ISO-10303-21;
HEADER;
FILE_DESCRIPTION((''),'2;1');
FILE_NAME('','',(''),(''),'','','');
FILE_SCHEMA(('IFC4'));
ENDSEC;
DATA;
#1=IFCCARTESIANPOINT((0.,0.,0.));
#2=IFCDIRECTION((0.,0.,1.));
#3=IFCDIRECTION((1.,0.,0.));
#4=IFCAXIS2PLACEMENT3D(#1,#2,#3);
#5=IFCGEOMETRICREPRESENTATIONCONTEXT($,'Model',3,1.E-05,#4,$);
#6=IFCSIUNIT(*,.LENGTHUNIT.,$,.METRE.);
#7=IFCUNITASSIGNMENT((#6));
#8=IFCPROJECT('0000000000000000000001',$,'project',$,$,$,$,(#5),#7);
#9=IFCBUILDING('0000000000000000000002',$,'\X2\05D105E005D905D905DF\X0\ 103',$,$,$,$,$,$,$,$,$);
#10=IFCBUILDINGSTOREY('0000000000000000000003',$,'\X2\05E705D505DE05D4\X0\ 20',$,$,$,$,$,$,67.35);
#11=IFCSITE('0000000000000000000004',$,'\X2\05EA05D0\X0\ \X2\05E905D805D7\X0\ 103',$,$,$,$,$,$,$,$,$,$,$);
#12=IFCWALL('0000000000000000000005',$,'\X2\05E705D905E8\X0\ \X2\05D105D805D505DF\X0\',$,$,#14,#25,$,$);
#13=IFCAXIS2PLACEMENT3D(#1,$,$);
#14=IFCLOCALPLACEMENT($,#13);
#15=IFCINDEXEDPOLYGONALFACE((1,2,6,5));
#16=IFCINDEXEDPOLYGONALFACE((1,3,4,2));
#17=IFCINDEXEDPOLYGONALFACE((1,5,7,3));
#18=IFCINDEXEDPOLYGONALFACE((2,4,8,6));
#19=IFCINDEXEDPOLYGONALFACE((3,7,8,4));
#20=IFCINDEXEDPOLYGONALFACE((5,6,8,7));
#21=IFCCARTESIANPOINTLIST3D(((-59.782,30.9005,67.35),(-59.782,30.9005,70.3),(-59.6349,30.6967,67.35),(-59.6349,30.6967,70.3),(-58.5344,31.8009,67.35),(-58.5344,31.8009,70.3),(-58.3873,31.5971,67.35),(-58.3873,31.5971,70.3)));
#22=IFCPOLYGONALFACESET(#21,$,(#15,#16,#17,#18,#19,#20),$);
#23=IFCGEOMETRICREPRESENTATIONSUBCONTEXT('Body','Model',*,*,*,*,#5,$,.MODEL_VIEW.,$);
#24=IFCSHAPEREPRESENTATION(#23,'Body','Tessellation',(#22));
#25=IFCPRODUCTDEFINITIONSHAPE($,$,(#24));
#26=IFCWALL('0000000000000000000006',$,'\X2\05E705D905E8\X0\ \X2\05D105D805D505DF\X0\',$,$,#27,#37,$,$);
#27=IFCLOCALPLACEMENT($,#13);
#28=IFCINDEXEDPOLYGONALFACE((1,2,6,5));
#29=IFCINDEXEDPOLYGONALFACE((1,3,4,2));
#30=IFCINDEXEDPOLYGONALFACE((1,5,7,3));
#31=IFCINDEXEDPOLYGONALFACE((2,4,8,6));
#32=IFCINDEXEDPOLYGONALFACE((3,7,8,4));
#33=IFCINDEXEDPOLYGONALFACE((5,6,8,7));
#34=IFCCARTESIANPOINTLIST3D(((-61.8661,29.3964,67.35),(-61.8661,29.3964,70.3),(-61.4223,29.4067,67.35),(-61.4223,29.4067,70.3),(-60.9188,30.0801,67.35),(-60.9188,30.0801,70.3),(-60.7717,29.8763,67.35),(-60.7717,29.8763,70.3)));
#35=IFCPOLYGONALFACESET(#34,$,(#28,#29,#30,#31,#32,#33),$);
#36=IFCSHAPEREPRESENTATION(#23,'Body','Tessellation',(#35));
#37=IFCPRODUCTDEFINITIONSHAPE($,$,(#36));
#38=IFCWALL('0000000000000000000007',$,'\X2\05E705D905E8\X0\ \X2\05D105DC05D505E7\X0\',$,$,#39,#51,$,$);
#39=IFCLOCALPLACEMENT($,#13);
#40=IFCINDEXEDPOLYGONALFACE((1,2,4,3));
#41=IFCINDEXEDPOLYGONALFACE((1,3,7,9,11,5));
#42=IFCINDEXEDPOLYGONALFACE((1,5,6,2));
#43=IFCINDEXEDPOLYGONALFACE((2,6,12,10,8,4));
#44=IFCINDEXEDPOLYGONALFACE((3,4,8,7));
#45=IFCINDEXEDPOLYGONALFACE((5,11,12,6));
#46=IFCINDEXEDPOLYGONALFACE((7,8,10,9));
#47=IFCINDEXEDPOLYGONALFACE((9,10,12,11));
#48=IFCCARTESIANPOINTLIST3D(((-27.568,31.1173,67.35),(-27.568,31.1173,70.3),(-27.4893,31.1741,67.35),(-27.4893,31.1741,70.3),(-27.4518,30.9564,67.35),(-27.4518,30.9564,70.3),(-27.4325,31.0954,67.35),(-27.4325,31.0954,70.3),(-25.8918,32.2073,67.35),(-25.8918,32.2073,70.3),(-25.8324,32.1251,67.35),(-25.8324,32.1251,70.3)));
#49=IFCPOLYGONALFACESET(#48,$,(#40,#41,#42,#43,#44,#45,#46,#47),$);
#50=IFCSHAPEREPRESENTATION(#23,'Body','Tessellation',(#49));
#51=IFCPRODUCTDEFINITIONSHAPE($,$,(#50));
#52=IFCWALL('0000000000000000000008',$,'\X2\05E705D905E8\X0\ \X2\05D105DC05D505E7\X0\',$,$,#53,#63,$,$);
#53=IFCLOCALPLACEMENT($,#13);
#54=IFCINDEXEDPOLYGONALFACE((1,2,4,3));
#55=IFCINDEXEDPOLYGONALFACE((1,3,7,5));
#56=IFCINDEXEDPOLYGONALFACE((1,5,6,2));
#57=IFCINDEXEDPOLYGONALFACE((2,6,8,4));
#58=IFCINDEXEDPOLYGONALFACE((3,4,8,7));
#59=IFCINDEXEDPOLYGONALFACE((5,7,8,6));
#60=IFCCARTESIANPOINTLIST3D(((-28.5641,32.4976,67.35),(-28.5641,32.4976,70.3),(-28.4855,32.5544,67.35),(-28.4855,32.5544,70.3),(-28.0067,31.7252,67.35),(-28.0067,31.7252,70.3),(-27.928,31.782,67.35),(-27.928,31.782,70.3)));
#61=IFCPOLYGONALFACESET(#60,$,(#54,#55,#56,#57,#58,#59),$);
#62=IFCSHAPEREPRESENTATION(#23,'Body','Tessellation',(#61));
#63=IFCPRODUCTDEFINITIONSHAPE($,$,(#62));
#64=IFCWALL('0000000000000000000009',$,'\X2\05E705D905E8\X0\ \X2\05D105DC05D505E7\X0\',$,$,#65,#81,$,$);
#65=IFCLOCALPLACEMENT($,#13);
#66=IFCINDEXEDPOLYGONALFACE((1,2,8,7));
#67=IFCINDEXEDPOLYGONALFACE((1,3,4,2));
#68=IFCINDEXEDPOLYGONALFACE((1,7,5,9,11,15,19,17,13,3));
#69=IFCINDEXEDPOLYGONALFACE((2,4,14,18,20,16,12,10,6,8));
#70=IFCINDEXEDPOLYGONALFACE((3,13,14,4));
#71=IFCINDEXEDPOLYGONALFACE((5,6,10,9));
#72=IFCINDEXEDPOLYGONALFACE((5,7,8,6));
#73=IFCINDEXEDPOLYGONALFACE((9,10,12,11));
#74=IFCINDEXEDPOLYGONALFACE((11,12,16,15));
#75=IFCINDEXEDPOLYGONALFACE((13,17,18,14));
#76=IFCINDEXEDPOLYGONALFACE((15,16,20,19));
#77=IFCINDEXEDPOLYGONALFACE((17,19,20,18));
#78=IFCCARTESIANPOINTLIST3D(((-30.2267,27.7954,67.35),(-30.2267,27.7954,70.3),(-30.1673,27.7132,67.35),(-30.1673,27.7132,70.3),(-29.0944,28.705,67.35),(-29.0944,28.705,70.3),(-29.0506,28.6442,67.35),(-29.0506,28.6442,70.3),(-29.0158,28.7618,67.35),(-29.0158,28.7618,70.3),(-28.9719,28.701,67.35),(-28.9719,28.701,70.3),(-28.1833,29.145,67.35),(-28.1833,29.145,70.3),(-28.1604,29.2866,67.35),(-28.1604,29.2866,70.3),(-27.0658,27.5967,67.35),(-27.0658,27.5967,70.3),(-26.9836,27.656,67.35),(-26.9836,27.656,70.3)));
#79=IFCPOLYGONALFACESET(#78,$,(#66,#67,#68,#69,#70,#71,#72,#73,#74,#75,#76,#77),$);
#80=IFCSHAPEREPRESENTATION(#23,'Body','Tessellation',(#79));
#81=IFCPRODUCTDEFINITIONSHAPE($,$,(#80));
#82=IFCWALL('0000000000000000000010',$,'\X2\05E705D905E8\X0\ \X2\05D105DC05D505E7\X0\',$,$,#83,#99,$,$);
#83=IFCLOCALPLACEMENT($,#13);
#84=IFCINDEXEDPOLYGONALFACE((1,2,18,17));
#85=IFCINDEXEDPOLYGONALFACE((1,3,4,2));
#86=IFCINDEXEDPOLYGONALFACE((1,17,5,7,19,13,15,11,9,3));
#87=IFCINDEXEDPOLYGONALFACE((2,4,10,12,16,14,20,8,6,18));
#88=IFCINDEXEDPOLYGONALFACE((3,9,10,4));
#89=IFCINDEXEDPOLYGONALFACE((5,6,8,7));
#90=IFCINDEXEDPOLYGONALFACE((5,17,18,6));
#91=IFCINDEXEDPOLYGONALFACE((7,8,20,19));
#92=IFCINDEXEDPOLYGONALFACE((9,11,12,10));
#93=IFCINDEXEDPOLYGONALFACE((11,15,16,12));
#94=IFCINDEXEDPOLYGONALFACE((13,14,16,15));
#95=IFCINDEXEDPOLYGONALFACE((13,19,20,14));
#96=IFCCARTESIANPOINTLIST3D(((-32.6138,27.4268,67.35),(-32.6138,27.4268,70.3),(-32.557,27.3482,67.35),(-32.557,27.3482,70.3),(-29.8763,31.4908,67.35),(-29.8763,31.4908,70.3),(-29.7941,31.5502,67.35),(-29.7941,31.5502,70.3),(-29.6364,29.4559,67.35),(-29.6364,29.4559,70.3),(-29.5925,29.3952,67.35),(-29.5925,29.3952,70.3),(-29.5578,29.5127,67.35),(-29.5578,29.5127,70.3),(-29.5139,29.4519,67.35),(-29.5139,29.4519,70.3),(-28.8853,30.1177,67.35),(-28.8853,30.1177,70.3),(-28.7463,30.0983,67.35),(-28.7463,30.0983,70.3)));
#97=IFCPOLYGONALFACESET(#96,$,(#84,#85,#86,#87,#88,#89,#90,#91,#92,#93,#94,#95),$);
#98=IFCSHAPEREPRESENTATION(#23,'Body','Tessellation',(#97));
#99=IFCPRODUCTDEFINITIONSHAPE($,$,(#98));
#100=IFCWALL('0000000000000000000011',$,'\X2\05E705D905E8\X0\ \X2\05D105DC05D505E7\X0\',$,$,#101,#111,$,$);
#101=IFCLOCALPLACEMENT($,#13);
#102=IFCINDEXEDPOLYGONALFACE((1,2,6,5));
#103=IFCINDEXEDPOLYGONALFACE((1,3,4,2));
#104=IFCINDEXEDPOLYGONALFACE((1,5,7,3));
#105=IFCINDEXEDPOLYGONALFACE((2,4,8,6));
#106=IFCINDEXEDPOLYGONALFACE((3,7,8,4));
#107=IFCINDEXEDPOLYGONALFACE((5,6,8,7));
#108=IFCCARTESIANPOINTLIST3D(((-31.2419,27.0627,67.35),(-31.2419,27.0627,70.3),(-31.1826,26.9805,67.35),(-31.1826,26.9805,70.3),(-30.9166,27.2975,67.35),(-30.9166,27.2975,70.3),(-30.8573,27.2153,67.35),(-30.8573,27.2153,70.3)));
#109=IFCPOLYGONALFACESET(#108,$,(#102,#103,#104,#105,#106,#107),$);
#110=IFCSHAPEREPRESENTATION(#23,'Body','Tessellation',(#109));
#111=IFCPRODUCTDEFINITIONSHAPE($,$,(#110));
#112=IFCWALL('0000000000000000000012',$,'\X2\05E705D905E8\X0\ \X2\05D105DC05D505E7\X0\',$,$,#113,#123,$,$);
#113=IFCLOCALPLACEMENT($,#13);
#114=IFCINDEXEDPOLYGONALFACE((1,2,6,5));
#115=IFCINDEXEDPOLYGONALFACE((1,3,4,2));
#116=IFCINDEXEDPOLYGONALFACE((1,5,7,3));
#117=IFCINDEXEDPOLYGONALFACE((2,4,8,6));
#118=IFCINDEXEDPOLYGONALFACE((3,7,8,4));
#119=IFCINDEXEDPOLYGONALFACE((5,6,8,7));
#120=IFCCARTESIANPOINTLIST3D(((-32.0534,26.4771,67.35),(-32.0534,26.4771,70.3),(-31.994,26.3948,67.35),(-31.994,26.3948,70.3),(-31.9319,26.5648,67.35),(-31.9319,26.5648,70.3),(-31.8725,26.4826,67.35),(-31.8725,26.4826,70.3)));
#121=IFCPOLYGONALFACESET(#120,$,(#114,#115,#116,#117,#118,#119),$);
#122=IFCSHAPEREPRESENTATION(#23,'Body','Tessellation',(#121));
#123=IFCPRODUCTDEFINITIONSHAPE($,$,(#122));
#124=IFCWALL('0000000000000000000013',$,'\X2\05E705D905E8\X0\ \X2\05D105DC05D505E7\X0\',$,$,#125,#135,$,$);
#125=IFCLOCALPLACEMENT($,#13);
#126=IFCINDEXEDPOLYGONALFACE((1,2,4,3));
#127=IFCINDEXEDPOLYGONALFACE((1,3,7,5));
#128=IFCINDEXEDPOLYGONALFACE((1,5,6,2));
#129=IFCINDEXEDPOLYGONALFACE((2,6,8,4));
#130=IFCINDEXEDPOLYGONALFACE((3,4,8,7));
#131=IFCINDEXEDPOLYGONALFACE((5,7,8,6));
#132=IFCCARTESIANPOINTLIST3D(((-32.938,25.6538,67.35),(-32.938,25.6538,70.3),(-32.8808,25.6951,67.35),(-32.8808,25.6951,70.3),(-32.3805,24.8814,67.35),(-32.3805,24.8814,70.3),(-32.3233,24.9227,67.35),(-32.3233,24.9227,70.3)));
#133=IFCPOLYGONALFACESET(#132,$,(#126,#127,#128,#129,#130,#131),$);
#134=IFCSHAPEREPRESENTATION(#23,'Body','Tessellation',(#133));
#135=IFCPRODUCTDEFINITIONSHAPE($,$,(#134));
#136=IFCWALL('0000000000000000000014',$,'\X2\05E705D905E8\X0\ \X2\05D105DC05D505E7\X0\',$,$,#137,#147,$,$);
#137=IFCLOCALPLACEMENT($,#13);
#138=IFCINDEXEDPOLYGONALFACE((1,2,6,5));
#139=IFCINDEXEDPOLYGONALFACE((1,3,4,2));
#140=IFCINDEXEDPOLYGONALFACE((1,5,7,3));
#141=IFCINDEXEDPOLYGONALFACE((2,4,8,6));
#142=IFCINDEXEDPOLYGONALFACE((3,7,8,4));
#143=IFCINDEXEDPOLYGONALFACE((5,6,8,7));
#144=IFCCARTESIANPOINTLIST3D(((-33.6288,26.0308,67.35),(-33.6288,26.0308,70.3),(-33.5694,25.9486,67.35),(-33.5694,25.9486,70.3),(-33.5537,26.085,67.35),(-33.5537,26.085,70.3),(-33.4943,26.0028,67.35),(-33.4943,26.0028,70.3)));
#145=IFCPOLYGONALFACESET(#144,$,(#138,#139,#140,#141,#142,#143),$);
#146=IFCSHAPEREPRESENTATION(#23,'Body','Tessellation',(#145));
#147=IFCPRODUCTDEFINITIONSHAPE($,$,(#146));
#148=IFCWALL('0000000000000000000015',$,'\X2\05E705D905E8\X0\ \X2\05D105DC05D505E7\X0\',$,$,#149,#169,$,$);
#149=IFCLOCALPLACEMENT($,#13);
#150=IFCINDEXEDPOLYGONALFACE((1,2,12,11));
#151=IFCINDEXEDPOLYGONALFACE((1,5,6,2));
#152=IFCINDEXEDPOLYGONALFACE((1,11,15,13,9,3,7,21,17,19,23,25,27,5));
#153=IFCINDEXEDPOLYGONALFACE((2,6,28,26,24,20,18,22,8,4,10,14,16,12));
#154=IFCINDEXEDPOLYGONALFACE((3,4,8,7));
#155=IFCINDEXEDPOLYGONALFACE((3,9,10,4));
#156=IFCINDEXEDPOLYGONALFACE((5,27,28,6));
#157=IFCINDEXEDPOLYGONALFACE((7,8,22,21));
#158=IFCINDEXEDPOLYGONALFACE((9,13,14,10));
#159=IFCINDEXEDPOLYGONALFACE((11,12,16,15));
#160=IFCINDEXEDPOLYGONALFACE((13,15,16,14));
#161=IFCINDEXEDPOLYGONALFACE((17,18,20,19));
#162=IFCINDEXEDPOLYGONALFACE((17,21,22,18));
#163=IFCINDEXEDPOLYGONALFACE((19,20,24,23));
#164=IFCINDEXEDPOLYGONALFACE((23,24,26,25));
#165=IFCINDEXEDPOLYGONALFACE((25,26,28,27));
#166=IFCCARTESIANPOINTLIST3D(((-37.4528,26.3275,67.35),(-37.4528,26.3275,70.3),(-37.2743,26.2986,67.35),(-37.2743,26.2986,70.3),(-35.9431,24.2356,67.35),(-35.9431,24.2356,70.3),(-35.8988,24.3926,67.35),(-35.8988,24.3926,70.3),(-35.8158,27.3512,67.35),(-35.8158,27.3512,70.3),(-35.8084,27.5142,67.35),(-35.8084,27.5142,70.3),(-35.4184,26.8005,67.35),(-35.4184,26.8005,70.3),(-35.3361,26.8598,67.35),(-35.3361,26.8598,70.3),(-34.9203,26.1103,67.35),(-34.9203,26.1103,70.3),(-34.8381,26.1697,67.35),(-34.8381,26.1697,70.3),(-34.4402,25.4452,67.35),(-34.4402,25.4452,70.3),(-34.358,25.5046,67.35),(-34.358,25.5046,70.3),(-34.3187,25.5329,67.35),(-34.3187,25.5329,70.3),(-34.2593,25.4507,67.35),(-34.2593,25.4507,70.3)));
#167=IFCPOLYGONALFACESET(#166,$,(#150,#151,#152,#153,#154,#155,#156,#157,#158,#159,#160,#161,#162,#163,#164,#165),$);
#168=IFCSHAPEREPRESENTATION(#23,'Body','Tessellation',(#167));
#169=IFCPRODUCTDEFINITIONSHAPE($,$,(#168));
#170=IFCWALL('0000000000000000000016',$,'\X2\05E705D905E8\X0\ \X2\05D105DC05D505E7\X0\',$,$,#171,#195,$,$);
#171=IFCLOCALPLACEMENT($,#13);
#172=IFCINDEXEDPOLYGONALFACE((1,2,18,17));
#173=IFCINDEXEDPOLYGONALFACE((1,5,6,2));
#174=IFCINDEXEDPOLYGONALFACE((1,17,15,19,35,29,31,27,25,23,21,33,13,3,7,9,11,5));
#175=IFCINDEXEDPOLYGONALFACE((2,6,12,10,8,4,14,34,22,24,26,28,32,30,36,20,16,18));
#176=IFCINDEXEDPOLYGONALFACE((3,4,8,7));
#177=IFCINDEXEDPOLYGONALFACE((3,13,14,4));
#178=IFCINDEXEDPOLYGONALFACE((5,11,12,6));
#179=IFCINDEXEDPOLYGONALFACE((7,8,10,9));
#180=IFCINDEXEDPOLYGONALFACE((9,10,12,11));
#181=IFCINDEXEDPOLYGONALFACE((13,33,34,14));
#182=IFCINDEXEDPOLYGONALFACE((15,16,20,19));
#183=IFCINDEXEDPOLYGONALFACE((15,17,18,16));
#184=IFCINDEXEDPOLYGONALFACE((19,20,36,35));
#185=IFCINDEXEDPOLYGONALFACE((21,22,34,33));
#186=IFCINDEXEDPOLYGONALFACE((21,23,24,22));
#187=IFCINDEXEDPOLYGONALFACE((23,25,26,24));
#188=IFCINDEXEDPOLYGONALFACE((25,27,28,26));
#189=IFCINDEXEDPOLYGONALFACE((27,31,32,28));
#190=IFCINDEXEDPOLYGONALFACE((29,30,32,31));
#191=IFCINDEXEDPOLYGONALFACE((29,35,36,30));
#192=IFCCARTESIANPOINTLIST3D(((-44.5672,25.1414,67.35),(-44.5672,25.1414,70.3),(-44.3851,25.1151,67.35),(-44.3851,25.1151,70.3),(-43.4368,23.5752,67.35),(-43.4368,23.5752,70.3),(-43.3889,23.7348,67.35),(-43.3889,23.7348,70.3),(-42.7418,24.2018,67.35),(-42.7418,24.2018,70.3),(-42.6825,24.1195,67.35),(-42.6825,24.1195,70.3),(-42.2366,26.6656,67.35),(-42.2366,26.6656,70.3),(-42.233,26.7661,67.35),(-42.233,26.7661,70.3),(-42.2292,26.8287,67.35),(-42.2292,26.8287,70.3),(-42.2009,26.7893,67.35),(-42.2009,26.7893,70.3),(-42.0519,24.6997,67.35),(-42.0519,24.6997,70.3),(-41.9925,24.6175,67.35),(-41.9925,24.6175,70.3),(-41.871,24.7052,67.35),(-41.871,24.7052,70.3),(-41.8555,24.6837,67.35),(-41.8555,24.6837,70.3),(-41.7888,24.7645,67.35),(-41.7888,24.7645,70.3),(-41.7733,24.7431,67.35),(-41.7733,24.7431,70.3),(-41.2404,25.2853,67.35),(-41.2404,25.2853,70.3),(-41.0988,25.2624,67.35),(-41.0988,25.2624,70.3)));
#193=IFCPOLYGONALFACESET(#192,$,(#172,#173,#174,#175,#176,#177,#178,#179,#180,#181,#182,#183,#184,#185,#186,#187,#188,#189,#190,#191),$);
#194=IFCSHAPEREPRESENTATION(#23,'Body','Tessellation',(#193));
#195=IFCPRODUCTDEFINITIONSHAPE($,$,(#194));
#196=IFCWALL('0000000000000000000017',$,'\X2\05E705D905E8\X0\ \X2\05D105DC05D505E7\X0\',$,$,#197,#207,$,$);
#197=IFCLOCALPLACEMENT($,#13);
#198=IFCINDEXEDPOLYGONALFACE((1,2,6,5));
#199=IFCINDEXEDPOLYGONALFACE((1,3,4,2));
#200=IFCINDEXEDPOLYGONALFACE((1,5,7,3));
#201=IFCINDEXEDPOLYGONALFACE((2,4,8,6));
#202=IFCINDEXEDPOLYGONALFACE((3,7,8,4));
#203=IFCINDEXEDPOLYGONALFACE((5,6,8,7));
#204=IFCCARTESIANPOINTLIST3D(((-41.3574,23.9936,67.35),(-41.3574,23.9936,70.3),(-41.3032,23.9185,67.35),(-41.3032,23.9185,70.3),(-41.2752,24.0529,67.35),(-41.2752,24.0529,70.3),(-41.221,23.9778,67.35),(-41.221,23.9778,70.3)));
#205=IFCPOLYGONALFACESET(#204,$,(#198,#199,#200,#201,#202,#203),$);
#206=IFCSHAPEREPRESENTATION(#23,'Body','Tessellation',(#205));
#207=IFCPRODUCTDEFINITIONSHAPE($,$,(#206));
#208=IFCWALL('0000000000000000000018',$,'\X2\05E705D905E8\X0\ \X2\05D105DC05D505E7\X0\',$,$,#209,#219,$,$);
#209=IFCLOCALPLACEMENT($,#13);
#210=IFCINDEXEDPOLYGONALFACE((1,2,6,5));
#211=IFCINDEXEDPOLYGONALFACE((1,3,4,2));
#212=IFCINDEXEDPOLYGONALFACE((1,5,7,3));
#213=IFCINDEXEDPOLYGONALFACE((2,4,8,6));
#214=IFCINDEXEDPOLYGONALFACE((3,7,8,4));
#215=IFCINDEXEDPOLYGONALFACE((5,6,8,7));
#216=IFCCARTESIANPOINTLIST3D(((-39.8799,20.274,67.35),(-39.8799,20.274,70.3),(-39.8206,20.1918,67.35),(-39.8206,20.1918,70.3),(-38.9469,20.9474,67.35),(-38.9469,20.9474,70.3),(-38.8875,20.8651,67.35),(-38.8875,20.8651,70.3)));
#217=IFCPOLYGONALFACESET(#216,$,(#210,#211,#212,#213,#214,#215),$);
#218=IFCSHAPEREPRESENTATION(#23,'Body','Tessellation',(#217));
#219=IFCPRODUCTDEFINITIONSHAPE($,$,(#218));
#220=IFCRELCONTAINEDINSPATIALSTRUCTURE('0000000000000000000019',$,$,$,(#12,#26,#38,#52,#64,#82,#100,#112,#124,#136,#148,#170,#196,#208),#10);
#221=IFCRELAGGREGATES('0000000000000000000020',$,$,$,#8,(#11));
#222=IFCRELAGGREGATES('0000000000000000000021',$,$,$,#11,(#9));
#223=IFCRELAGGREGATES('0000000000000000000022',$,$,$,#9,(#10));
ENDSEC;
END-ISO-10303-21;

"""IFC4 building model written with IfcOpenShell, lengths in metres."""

from ifc_helpers import new_model, si_unit, frame, origin_with_axes, context, subcontext, project, spatial, polyline, outline, extrude, element, save


model = new_model("IFC4")

# Units and contexts
model_context = context("Model", 3, precision=1e-05, world=origin_with_axes())
body_context = subcontext(model_context, "Body", "Model", "MODEL_VIEW")
ifc_project = project(units=[si_unit("LENGTHUNIT", "METRE")], contexts=[model_context])

# Site, building, storey
site = spatial("IfcSite", under=ifc_project, Name="תא שטח 103")
building = spatial("IfcBuilding", under=site, Name="בניין 103")
storey = spatial("IfcBuildingStorey", under=building, Name="קומה 20", Elevation=67.35)

# Walls
element("IfcWall", 1, inside=storey, Name="קיר בטון", context=body_context, shape_type="SweptSolid", body=[
    extrude(outline(polyline([(-59.6349, 30.6967), (-59.782, 30.9005), (-58.5344, 31.8009), (-58.3873, 31.5971), (-59.6349, 30.6967)])), frame((0.0, 0.0, 67.35)), (0.0, 0.0, 1.0), 2.95),
])
element("IfcWall", 2, inside=storey, Name="קיר בטון", context=body_context, shape_type="SweptSolid", body=[
    extrude(outline(polyline([(-61.4223, 29.4067), (-61.8661, 29.3964), (-60.9188, 30.0801), (-60.7717, 29.8763), (-61.4223, 29.4067)])), frame((0.0, 0.0, 67.35)), (0.0, 0.0, 1.0), 2.95),
])
element("IfcWall", 3, inside=storey, Name="קיר בלוק", context=body_context, shape_type="SweptSolid", body=[
    extrude(outline(polyline([(-27.4893, 31.1741), (-27.4325, 31.0954), (-25.8918, 32.2073), (-25.8324, 32.1251), (-27.4518, 30.9564), (-27.568, 31.1173), (-27.4893, 31.1741)])), frame((0.0, 0.0, 67.35)), (0.0, 0.0, 1.0), 2.95),
])
element("IfcWall", 4, inside=storey, Name="קיר בלוק", context=body_context, shape_type="SweptSolid", body=[
    extrude(outline(polyline([(-28.4855, 32.5544), (-27.928, 31.782), (-28.0067, 31.7252), (-28.5641, 32.4976), (-28.4855, 32.5544)])), frame((0.0, 0.0, 67.35)), (0.0, 0.0, 1.0), 2.95),
])
element("IfcWall", 5, inside=storey, Name="קיר בלוק", context=body_context, shape_type="SweptSolid", body=[
    extrude(outline(polyline([(-30.1673, 27.7132), (-30.2267, 27.7954), (-29.0506, 28.6442), (-29.0944, 28.705), (-29.0158, 28.7618), (-28.9719, 28.701), (-28.1604, 29.2866), (-26.9836, 27.656), (-27.0658, 27.5967), (-28.1833, 29.145), (-30.1673, 27.7132)])), frame((0.0, 0.0, 67.35)), (0.0, 0.0, 1.0), 2.95),
])
element("IfcWall", 6, inside=storey, Name="קיר בלוק", context=body_context, shape_type="SweptSolid", body=[
    extrude(outline(polyline([(-29.5925, 29.3952), (-29.6364, 29.4559), (-32.557, 27.3482), (-32.6138, 27.4268), (-28.8853, 30.1177), (-29.8763, 31.4908), (-29.7941, 31.5502), (-28.7463, 30.0983), (-29.5578, 29.5127), (-29.5139, 29.4519), (-29.5925, 29.3952)])), frame((0.0, 0.0, 67.35)), (0.0, 0.0, 1.0), 2.95),
])
element("IfcWall", 7, inside=storey, Name="קיר בלוק", context=body_context, shape_type="SweptSolid", body=[
    extrude(outline(polyline([(-30.9166, 27.2975), (-30.8573, 27.2153), (-31.1826, 26.9805), (-31.2419, 27.0627), (-30.9166, 27.2975)])), frame((0.0, 0.0, 67.35)), (0.0, 0.0, 1.0), 2.95),
])
element("IfcWall", 8, inside=storey, Name="קיר בלוק", context=body_context, shape_type="SweptSolid", body=[
    extrude(outline(polyline([(-31.8725, 26.4826), (-31.994, 26.3948), (-32.0534, 26.4771), (-31.9319, 26.5648), (-31.8725, 26.4826)])), frame((0.0, 0.0, 67.35)), (0.0, 0.0, 1.0), 2.95),
])
element("IfcWall", 9, inside=storey, Name="קיר בלוק", context=body_context, shape_type="SweptSolid", body=[
    extrude(outline(polyline([(-32.3233, 24.9227), (-32.3805, 24.8814), (-32.938, 25.6538), (-32.8808, 25.6951), (-32.3233, 24.9227)])), frame((0.0, 0.0, 67.35)), (0.0, 0.0, 1.0), 2.95),
])
element("IfcWall", 10, inside=storey, Name="קיר בלוק", context=body_context, shape_type="SweptSolid", body=[
    extrude(outline(polyline([(-33.5537, 26.085), (-33.4943, 26.0028), (-33.5694, 25.9486), (-33.6288, 26.0308), (-33.5537, 26.085)])), frame((0.0, 0.0, 67.35)), (0.0, 0.0, 1.0), 2.95),
])
element("IfcWall", 11, inside=storey, Name="קיר בלוק", context=body_context, shape_type="SweptSolid", body=[
    extrude(outline(polyline([(-35.8988, 24.3926), (-34.4402, 25.4452), (-34.9203, 26.1103), (-34.8381, 26.1697), (-34.358, 25.5046), (-34.3187, 25.5329), (-34.2593, 25.4507), (-35.9431, 24.2356), (-37.4528, 26.3275), (-35.8084, 27.5142), (-35.3361, 26.8598), (-35.4184, 26.8005), (-35.8158, 27.3512), (-37.2743, 26.2986), (-35.8988, 24.3926)])), frame((0.0, 0.0, 67.35)), (0.0, 0.0, 1.0), 2.95),
])
element("IfcWall", 12, inside=storey, Name="קיר בלוק", context=body_context, shape_type="SweptSolid", body=[
    extrude(outline(polyline([(-41.8555, 24.6837), (-41.871, 24.7052), (-41.9925, 24.6175), (-42.0519, 24.6997), (-41.2404, 25.2853), (-42.2366, 26.6656), (-44.3851, 25.1151), (-43.3889, 23.7348), (-42.7418, 24.2018), (-42.6825, 24.1195), (-43.4368, 23.5752), (-44.5672, 25.1414), (-42.2292, 26.8287), (-42.233, 26.7661), (-42.2009, 26.7893), (-41.0988, 25.2624), (-41.7888, 24.7645), (-41.7733, 24.7431), (-41.8555, 24.6837)])), frame((0.0, 0.0, 67.35)), (0.0, 0.0, 1.0), 2.95),
])
element("IfcWall", 13, inside=storey, Name="קיר בלוק", context=body_context, shape_type="SweptSolid", body=[
    extrude(outline(polyline([(-41.221, 23.9778), (-41.3032, 23.9185), (-41.3574, 23.9936), (-41.2752, 24.0529), (-41.221, 23.9778)])), frame((0.0, 0.0, 67.35)), (0.0, 0.0, 1.0), 2.95),
])
element("IfcWall", 14, inside=storey, Name="קיר בלוק", context=body_context, shape_type="SweptSolid", body=[
    extrude(outline(polyline([(-39.8206, 20.1918), (-39.8799, 20.274), (-38.9469, 20.9474), (-38.8875, 20.8651), (-39.8206, 20.1918)])), frame((0.0, 0.0, 67.35)), (0.0, 0.0, 1.0), 2.95),
])

save(model, "model.ifc")
